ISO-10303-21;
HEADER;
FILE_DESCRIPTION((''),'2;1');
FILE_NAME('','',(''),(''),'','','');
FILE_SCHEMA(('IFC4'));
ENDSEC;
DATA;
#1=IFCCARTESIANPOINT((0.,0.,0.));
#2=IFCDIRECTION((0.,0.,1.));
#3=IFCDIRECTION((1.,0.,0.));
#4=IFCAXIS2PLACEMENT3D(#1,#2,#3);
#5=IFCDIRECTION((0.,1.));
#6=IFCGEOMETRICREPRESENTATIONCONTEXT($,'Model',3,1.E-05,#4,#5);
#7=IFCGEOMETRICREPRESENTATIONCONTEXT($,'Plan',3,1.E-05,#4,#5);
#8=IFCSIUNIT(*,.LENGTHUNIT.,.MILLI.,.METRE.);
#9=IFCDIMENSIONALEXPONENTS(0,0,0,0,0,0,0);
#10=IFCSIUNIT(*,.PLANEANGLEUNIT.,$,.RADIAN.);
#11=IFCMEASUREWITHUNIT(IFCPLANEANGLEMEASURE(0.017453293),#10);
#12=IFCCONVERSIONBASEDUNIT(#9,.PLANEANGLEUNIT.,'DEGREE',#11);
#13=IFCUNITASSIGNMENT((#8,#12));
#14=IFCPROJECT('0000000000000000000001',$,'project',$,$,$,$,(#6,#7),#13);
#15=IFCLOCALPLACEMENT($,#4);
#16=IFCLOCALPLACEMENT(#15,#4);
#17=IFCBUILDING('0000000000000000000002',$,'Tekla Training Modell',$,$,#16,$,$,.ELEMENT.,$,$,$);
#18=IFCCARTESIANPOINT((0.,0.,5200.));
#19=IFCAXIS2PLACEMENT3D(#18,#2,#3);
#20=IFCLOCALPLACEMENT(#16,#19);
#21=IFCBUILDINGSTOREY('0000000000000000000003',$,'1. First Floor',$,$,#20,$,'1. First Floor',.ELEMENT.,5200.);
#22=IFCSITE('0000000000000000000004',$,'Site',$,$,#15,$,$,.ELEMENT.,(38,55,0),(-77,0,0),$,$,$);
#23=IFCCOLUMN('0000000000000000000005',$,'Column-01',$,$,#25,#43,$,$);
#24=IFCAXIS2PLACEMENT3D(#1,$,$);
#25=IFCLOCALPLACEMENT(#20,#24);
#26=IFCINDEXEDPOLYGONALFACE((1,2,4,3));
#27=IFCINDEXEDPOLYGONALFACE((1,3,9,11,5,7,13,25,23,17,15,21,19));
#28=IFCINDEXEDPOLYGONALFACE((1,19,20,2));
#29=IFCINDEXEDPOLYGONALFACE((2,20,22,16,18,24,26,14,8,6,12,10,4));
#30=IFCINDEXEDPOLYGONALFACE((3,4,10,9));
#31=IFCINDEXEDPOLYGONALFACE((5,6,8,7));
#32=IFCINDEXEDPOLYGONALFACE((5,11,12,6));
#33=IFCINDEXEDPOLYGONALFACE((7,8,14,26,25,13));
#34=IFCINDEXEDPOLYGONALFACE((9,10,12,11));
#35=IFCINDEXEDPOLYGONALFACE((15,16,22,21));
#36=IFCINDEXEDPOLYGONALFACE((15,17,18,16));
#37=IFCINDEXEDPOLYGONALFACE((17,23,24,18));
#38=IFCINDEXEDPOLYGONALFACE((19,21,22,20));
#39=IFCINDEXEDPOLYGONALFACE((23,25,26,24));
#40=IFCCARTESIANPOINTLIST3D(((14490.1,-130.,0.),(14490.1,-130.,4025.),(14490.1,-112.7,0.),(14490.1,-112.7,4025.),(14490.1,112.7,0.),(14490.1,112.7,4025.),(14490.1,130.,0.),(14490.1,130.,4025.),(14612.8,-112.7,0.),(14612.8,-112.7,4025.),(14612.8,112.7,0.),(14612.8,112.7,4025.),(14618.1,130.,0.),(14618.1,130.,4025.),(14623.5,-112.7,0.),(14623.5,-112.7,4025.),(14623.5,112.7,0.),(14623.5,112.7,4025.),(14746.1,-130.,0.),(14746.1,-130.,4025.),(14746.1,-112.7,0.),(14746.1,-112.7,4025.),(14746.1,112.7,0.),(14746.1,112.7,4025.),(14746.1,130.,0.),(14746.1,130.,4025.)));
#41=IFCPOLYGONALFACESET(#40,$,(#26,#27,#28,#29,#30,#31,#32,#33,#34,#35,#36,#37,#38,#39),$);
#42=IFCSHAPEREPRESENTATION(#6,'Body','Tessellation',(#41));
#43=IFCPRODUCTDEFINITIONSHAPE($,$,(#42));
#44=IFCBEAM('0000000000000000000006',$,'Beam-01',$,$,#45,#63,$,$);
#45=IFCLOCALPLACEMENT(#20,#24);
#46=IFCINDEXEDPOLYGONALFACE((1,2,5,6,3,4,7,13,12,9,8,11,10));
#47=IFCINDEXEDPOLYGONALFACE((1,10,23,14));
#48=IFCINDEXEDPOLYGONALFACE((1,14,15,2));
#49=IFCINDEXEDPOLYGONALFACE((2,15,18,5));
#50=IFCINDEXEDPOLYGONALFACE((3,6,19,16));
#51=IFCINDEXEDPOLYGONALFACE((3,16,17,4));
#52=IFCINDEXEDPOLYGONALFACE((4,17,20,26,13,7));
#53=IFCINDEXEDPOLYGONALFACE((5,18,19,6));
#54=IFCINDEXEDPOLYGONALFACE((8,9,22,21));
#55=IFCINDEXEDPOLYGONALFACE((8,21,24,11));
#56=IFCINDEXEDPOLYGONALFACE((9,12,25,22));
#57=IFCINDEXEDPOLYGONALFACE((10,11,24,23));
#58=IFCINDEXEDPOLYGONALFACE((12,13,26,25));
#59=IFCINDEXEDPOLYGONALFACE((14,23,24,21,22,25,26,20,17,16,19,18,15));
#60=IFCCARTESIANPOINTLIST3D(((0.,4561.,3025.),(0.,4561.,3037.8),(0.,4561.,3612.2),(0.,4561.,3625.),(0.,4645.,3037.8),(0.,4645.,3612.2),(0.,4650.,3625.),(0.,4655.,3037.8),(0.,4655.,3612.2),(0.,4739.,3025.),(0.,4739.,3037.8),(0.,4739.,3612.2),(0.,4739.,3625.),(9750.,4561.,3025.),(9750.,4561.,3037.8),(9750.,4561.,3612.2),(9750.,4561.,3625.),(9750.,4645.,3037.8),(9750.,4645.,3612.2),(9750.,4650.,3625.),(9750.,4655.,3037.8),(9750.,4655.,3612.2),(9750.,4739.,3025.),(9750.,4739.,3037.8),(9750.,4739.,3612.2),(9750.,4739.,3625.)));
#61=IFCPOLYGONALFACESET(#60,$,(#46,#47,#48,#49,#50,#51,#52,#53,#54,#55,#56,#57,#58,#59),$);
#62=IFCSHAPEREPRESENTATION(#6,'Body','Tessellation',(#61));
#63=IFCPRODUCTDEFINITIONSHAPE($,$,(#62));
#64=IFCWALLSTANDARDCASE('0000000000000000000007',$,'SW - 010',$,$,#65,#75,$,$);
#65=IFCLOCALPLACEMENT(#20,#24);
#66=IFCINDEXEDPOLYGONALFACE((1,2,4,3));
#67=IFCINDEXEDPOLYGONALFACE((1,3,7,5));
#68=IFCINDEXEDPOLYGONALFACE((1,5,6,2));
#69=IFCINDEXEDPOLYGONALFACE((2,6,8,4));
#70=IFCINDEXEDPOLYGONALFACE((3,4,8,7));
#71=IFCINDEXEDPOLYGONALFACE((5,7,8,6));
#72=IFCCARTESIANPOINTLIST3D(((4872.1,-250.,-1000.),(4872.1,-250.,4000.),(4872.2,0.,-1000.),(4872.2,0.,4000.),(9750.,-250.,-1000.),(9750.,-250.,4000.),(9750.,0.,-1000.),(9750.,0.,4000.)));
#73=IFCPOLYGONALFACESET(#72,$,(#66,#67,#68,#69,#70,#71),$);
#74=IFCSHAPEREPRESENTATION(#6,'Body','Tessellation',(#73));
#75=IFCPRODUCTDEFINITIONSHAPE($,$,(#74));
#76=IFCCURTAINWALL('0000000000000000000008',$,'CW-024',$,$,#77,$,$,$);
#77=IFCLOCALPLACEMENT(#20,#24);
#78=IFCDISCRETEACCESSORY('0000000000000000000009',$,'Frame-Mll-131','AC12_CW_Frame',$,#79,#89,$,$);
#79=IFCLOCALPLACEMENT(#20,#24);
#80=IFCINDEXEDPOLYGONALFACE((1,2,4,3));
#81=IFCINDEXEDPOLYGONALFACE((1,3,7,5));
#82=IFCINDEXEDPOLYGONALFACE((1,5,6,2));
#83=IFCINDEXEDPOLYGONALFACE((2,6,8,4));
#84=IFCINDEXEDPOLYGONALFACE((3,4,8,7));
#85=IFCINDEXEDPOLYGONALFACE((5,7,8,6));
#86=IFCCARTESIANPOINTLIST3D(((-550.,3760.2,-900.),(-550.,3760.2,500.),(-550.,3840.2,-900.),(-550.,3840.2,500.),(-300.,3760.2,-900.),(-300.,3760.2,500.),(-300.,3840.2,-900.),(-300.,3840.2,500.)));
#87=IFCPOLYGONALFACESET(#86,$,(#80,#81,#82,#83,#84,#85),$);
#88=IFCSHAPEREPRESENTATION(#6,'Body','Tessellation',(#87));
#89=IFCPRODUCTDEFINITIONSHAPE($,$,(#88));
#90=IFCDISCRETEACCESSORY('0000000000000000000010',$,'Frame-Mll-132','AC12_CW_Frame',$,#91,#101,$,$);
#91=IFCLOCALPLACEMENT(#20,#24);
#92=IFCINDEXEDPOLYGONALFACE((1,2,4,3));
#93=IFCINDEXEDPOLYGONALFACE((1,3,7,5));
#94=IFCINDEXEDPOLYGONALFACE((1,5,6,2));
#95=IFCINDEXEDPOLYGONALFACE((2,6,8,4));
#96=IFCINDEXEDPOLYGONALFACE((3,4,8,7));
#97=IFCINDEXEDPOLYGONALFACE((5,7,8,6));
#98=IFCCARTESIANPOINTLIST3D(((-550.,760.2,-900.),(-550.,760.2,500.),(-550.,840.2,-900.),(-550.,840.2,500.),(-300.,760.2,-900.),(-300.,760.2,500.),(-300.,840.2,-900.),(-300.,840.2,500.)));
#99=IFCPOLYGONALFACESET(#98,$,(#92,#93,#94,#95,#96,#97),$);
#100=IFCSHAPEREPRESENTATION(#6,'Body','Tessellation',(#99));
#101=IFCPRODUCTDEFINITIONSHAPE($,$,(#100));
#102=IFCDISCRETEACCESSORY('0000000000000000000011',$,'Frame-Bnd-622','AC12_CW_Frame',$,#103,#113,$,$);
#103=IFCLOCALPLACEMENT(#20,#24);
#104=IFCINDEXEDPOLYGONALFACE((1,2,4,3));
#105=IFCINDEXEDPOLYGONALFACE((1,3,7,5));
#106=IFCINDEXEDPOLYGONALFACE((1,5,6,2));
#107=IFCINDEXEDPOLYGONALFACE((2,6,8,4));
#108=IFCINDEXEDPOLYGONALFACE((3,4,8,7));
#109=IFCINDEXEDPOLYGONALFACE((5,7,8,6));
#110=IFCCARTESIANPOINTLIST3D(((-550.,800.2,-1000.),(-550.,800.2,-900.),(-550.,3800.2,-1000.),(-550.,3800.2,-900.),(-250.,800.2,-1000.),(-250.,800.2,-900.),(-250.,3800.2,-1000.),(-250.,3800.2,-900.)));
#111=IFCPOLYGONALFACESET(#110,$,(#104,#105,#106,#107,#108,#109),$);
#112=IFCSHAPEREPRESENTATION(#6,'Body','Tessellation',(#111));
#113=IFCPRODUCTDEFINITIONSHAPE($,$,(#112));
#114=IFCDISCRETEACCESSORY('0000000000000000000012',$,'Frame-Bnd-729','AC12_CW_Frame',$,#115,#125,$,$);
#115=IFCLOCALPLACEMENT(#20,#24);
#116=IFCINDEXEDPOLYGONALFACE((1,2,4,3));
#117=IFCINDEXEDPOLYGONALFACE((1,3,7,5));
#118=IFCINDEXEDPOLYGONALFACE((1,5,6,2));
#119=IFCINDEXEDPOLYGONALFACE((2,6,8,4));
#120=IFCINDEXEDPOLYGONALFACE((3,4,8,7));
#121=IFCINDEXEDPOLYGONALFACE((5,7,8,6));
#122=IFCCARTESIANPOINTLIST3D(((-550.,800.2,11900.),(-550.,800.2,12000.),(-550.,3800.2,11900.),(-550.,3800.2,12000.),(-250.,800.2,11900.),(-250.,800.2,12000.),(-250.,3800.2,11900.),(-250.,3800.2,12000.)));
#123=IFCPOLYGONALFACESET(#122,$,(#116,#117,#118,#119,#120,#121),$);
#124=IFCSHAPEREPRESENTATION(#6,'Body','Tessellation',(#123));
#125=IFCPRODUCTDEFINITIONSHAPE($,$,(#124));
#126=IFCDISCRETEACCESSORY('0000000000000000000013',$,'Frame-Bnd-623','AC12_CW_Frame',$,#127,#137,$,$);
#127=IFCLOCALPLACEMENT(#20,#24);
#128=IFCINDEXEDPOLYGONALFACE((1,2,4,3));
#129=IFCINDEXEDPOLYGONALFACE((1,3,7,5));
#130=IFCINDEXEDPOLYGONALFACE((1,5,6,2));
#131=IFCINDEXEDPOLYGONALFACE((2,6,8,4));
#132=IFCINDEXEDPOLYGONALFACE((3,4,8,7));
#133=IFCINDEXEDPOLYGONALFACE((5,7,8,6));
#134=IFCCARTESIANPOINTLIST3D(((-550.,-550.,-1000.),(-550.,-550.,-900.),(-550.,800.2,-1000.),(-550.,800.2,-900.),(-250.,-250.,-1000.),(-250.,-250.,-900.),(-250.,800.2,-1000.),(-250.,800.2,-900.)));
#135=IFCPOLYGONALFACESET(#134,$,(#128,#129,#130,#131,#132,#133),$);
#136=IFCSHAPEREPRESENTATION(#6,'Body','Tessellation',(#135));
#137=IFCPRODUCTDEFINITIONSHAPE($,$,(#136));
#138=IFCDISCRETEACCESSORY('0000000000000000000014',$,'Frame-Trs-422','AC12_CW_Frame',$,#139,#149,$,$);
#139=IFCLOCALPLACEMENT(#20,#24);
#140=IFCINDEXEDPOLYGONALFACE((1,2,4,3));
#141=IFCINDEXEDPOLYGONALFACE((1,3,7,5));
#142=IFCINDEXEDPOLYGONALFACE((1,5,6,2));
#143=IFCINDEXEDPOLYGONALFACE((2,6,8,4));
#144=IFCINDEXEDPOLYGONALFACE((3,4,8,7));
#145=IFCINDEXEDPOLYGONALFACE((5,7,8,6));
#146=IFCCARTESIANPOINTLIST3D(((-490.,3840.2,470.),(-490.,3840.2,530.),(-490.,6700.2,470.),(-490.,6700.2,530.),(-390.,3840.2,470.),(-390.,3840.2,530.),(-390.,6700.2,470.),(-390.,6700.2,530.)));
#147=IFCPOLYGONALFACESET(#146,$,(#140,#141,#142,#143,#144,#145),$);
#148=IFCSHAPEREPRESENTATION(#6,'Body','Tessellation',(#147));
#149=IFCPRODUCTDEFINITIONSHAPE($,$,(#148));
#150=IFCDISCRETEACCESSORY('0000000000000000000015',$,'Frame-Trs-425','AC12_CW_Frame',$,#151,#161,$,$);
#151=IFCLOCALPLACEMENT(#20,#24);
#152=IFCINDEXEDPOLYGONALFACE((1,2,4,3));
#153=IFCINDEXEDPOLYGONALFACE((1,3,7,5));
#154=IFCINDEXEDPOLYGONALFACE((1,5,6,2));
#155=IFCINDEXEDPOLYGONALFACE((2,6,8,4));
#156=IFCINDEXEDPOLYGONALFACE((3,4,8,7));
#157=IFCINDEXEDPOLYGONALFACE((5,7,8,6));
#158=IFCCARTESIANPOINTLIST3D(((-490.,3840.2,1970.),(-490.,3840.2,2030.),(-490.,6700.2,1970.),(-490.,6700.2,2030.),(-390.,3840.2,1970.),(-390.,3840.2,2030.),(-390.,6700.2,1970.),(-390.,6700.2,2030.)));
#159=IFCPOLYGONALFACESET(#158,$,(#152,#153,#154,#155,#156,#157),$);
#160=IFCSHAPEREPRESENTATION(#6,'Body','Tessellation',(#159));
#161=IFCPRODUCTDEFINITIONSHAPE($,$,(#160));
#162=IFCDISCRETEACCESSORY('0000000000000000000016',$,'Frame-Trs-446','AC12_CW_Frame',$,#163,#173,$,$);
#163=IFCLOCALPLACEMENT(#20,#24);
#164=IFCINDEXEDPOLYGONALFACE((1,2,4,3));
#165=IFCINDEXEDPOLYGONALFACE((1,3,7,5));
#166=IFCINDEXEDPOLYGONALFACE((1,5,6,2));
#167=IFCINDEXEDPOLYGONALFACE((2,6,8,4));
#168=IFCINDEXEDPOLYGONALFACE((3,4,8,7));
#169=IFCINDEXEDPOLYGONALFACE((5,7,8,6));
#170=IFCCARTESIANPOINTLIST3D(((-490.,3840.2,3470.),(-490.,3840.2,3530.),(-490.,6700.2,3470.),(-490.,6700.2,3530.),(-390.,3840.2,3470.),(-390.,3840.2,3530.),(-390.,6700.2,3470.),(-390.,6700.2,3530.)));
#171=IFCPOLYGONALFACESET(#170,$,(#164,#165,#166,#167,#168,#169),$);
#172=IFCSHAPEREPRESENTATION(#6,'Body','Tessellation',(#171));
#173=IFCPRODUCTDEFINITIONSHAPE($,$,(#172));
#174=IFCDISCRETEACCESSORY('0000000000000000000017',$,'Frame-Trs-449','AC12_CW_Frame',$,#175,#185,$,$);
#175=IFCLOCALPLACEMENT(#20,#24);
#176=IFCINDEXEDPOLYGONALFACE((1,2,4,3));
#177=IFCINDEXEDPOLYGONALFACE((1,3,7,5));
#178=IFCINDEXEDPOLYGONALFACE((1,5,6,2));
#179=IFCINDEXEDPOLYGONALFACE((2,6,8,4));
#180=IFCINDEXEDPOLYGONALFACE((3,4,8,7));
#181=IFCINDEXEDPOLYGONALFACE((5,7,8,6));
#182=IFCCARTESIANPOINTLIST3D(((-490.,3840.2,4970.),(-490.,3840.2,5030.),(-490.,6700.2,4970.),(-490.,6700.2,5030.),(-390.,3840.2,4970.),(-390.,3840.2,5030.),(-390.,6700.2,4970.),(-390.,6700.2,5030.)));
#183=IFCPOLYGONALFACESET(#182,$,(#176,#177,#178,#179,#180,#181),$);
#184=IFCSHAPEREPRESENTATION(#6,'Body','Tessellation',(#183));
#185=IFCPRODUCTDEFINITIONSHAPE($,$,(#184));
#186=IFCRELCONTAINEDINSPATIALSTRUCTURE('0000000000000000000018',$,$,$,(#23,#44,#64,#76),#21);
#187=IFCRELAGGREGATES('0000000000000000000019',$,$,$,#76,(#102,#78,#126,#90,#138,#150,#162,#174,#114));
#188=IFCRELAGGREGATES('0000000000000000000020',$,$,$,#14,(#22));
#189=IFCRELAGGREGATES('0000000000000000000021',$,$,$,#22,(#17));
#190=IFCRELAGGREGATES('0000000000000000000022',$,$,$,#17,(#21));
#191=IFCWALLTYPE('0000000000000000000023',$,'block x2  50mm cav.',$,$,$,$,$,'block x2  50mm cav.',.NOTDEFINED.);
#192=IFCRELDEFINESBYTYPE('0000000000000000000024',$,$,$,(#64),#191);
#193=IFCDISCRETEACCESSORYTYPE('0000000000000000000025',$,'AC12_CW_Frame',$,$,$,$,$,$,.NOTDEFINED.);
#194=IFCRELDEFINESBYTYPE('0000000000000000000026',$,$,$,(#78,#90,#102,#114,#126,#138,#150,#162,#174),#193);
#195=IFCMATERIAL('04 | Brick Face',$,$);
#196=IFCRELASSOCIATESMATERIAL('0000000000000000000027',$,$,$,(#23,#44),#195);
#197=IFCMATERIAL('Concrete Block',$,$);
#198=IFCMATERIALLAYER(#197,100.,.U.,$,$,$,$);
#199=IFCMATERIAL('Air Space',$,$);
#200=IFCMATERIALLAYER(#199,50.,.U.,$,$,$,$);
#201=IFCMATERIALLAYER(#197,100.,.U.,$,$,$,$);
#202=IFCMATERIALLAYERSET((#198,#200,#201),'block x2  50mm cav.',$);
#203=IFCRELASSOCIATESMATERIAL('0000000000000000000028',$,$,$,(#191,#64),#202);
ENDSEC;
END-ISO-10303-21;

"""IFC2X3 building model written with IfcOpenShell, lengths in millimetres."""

from ifc_helpers import new_model, entity, si_unit, converted_unit, direction, frame, origin_with_axes, place, context, project, spatial, polyline, outline, extrude, source, transform, mapped, material, layer, layer_set, layer_usage, type_object, element, aggregate, save


model = new_model("IFC2X3")

# Units and contexts
model_context = context("Model", 3, precision=1e-05, world=origin_with_axes(), true_north=direction((0.0, 1.0)))
plan_context = context("Plan", 3, precision=1e-05, world=origin_with_axes(), true_north=direction((0.0, 1.0)))
ifc_project = project(units=[si_unit("LENGTHUNIT", "METRE", prefix="MILLI"), converted_unit("PLANEANGLEUNIT", "DEGREE", entity("IfcPlaneAngleMeasure", 0.017453293), si_unit("PLANEANGLEUNIT", "RADIAN"), dimensions=[0, 0, 0, 0, 0, 0, 0])], contexts=[model_context, plan_context])

# Site, building, storey
site_placement = place(None, origin_with_axes())
site = spatial("IfcSite", under=ifc_project, at=site_placement, Name="Site", CompositionType="ELEMENT", RefLatitude=(38, 55, 0), RefLongitude=(-77, 0, 0))
building_placement = place(site_placement, origin_with_axes())
building = spatial("IfcBuilding", under=site, at=building_placement, Name="Tekla Training Modell", CompositionType="ELEMENT")
storey_placement = place(building_placement, frame((0.0, 0.0, 5200.0), z_axis=(0.0, 0.0, 1.0), x_axis=(1.0, 0.0, 0.0)))
storey = spatial("IfcBuildingStorey", under=building, at=storey_placement, Name="1. First Floor", LongName="1. First Floor", CompositionType="ELEMENT", Elevation=5200.0)

# Column
ifc_material_1 = material(Name="04 | Brick Face")
column_placement = place(storey_placement, frame((14618.1, 0.0, 0.0), z_axis=(0.0, 0.0, 1.0), x_axis=(1.0, 0.0, 0.0)))
element("IfcColumn", 1, at=column_placement, inside=storey, material=ifc_material_1, Name="Column-01", context=model_context, shape_type="SweptSolid", body=[
    extrude(outline(polyline([(0.0, 130.0), (-128.0, 130.0), (-128.0, 112.7), (-5.3, 112.7), (-5.3, -112.7), (-128.0, -112.7), (-128.0, -130.0), (128.0, -130.0), (128.0, -112.7), (5.3, -112.7), (5.3, 112.7), (128.0, 112.7), (128.0, 130.0), (0.0, 130.0)])), origin_with_axes(), (0.0, 0.0, 1.0), 4025.0),
])

# Beam
beam_placement = place(storey_placement, frame((0.0, 4650.0, 3325.0), z_axis=(0.0, 0.0, 1.0), x_axis=(0.0, -1.0, 0.0)))
element("IfcBeam", 2, at=beam_placement, inside=storey, material=ifc_material_1, Name="Beam-01", context=model_context, shape_type="SweptSolid", body=[
    extrude(outline(polyline([(0.0, 300.0), (-89.0, 300.0), (-89.0, 287.2), (-5.0, 287.2), (-5.0, -287.2), (-89.0, -287.2), (-89.0, -300.0), (89.0, -300.0), (89.0, -287.2), (5.0, -287.2), (5.0, 287.2), (89.0, 287.2), (89.0, 300.0), (0.0, 300.0)])), frame((0.0, 9750.0, 0.0), z_axis=(0.0, -1.0, 0.0), x_axis=(1.0, 0.0, 0.0)), (0.0, 0.0, 1.0), 9750.0),
])

# Wall
ifc_material_2 = material(Name="Concrete Block")
ifc_layer_1 = layer(ifc_material_2, 100.0, ventilated="UNKNOWN")
ifc_material_3 = material(Name="Air Space")
ifc_layer_2 = layer(ifc_material_3, 50.0, ventilated="UNKNOWN")
ifc_layer_3 = layer(ifc_material_2, 100.0, ventilated="UNKNOWN")
ifc_layer_set = layer_set([ifc_layer_1, ifc_layer_2, ifc_layer_3], Name="block x2  50mm cav.")
ifc_layer_usage = layer_usage(ifc_layer_set, "AXIS2", "NEGATIVE", 0.0)
wall_type = type_object("IfcWallType", Name="block x2  50mm cav.", ElementType="block x2  50mm cav.", PredefinedType="NOTDEFINED", material=ifc_layer_set)
wall_placement = place(storey_placement, frame((4872.1, 0.0, -1000.0), z_axis=(0.0, 0.0, 1.0), x_axis=(1.0, 0.0, 0.0)))
element("IfcWallStandardCase", 3, at=wall_placement, inside=storey, type_object=wall_type, material=ifc_layer_usage, Name="SW - 010", context=model_context, shape_type="SweptSolid", body=[
    extrude(outline(polyline([(0.0, -250.0), (4877.9, -250.0), (4877.9, 0.0), (0.0, 0.0), (0.0, -250.0)])), origin_with_axes(), (0.0, 0.0, 1.0), 5000.0),
])

# Curtain wall, discrete accessories
curtain_wall_placement = place(storey_placement, frame((-500.0, 6800.2, -1000.0), z_axis=(0.0, 0.0, 1.0), x_axis=(0.0, -1.0, 0.0)))
curtain_wall = element("IfcCurtainWall", 4, at=curtain_wall_placement, inside=storey, Name="CW-024")
discrete_accessory_type = type_object("IfcDiscreteAccessoryType", Name="AC12_CW_Frame")
shared_shape_1 = source(origin_with_axes(), model_context, "Body", "SweptSolid", [
    extrude(outline(polyline([(0.0, 0.0), (250.0, 0.0), (250.0, -1400.0), (0.0, -1400.0), (0.0, 0.0)])), origin_with_axes(), (0.0, 0.0, 1.0), 80.0),
])
discrete_accessory_1_placement = place(storey_placement, frame((-300.0, 3840.2, -900.0), z_axis=(0.0, -1.0, 0.0), x_axis=(-1.0, 0.0, 0.0)))
discrete_accessory_1 = element("IfcDiscreteAccessory", 5, at=discrete_accessory_1_placement, type_object=discrete_accessory_type, Name="Frame-Mll-131", Description="AC12_CW_Frame", context=model_context, shape_type="MappedRepresentation", body=[
    mapped(shared_shape_1, transform((0.0, 0.0, 0.0), scale=1.0)),
])
discrete_accessory_2_placement = place(storey_placement, frame((-300.0, 840.2, -900.0), z_axis=(0.0, -1.0, 0.0), x_axis=(-1.0, 0.0, 0.0)))
discrete_accessory_2 = element("IfcDiscreteAccessory", 6, at=discrete_accessory_2_placement, type_object=discrete_accessory_type, Name="Frame-Mll-132", Description="AC12_CW_Frame", context=model_context, shape_type="MappedRepresentation", body=[
    mapped(shared_shape_1, transform((0.0, 0.0, 0.0), scale=1.0)),
])
shared_shape_2 = source(origin_with_axes(), model_context, "Body", "SweptSolid", [
    extrude(outline(polyline([(0.0, 0.0), (300.0, 0.0), (300.0, -3000.0), (0.0, -3000.0), (0.0, 0.0)])), origin_with_axes(), (0.0, 0.0, 1.0), 100.0),
])
discrete_accessory_3_placement = place(storey_placement, frame((-250.0, 3800.2, -900.0), z_axis=(0.0, 0.0, -1.0), x_axis=(-1.0, 0.0, 0.0)))
discrete_accessory_3 = element("IfcDiscreteAccessory", 7, at=discrete_accessory_3_placement, type_object=discrete_accessory_type, Name="Frame-Bnd-622", Description="AC12_CW_Frame", context=model_context, shape_type="MappedRepresentation", body=[
    mapped(shared_shape_2, transform((0.0, 0.0, 0.0), scale=1.0)),
])
discrete_accessory_4_placement = place(storey_placement, frame((-250.0, 800.2, 11900.0), z_axis=(0.0, 0.0, 1.0), x_axis=(-1.0, 0.0, 0.0)))
discrete_accessory_4 = element("IfcDiscreteAccessory", 8, at=discrete_accessory_4_placement, type_object=discrete_accessory_type, Name="Frame-Bnd-729", Description="AC12_CW_Frame", context=model_context, shape_type="MappedRepresentation", body=[
    mapped(shared_shape_2, transform((0.0, 0.0, 0.0), scale=1.0)),
])
shared_shape_3 = source(origin_with_axes(), model_context, "Body", "SweptSolid", [
    extrude(outline(polyline([(0.0, 0.0), (300.0, 0.0), (300.0, -1350.2), (0.0, -1050.2), (0.0, 0.0)])), origin_with_axes(), (0.0, 0.0, 1.0), 100.0),
])
discrete_accessory_5_placement = place(storey_placement, frame((-250.0, 800.2, -900.0), z_axis=(0.0, 0.0, -1.0), x_axis=(-1.0, 0.0, 0.0)))
discrete_accessory_5 = element("IfcDiscreteAccessory", 9, at=discrete_accessory_5_placement, type_object=discrete_accessory_type, Name="Frame-Bnd-623", Description="AC12_CW_Frame", context=model_context, shape_type="MappedRepresentation", body=[
    mapped(shared_shape_3, transform((0.0, 0.0, 0.0), scale=1.0)),
])
shared_shape_4 = source(origin_with_axes(), model_context, "Body", "SweptSolid", [
    extrude(outline(polyline([(0.0, 0.0), (100.0, 0.0), (100.0, -2860.0), (0.0, -2860.0), (0.0, 0.0)])), origin_with_axes(), (0.0, 0.0, 1.0), 60.0),
])
discrete_accessory_6_placement = place(storey_placement, frame((-390.0, 6700.2, 530.0), z_axis=(0.0, 0.0, -1.0), x_axis=(-1.0, 0.0, 0.0)))
discrete_accessory_6 = element("IfcDiscreteAccessory", 10, at=discrete_accessory_6_placement, type_object=discrete_accessory_type, Name="Frame-Trs-422", Description="AC12_CW_Frame", context=model_context, shape_type="MappedRepresentation", body=[
    mapped(shared_shape_4, transform((0.0, 0.0, 0.0), scale=1.0)),
])
discrete_accessory_7_placement = place(storey_placement, frame((-390.0, 6700.2, 2030.0), z_axis=(0.0, 0.0, -1.0), x_axis=(-1.0, 0.0, 0.0)))
discrete_accessory_7 = element("IfcDiscreteAccessory", 11, at=discrete_accessory_7_placement, type_object=discrete_accessory_type, Name="Frame-Trs-425", Description="AC12_CW_Frame", context=model_context, shape_type="MappedRepresentation", body=[
    mapped(shared_shape_4, transform((0.0, 0.0, 0.0), scale=1.0)),
])
discrete_accessory_8_placement = place(storey_placement, frame((-390.0, 6700.2, 3530.0), z_axis=(0.0, 0.0, -1.0), x_axis=(-1.0, 0.0, 0.0)))
discrete_accessory_8 = element("IfcDiscreteAccessory", 12, at=discrete_accessory_8_placement, type_object=discrete_accessory_type, Name="Frame-Trs-446", Description="AC12_CW_Frame", context=model_context, shape_type="MappedRepresentation", body=[
    mapped(shared_shape_4, transform((0.0, 0.0, 0.0), scale=1.0)),
])
discrete_accessory_9_placement = place(storey_placement, frame((-390.0, 6700.2, 5030.0), z_axis=(0.0, 0.0, -1.0), x_axis=(-1.0, 0.0, 0.0)))
discrete_accessory_9 = element("IfcDiscreteAccessory", 13, at=discrete_accessory_9_placement, type_object=discrete_accessory_type, Name="Frame-Trs-449", Description="AC12_CW_Frame", context=model_context, shape_type="MappedRepresentation", body=[
    mapped(shared_shape_4, transform((0.0, 0.0, 0.0), scale=1.0)),
])
aggregate(curtain_wall, [discrete_accessory_3, discrete_accessory_1, discrete_accessory_5, discrete_accessory_2, discrete_accessory_6, discrete_accessory_7, discrete_accessory_8, discrete_accessory_9, discrete_accessory_4])

save(model, "model.ifc")
